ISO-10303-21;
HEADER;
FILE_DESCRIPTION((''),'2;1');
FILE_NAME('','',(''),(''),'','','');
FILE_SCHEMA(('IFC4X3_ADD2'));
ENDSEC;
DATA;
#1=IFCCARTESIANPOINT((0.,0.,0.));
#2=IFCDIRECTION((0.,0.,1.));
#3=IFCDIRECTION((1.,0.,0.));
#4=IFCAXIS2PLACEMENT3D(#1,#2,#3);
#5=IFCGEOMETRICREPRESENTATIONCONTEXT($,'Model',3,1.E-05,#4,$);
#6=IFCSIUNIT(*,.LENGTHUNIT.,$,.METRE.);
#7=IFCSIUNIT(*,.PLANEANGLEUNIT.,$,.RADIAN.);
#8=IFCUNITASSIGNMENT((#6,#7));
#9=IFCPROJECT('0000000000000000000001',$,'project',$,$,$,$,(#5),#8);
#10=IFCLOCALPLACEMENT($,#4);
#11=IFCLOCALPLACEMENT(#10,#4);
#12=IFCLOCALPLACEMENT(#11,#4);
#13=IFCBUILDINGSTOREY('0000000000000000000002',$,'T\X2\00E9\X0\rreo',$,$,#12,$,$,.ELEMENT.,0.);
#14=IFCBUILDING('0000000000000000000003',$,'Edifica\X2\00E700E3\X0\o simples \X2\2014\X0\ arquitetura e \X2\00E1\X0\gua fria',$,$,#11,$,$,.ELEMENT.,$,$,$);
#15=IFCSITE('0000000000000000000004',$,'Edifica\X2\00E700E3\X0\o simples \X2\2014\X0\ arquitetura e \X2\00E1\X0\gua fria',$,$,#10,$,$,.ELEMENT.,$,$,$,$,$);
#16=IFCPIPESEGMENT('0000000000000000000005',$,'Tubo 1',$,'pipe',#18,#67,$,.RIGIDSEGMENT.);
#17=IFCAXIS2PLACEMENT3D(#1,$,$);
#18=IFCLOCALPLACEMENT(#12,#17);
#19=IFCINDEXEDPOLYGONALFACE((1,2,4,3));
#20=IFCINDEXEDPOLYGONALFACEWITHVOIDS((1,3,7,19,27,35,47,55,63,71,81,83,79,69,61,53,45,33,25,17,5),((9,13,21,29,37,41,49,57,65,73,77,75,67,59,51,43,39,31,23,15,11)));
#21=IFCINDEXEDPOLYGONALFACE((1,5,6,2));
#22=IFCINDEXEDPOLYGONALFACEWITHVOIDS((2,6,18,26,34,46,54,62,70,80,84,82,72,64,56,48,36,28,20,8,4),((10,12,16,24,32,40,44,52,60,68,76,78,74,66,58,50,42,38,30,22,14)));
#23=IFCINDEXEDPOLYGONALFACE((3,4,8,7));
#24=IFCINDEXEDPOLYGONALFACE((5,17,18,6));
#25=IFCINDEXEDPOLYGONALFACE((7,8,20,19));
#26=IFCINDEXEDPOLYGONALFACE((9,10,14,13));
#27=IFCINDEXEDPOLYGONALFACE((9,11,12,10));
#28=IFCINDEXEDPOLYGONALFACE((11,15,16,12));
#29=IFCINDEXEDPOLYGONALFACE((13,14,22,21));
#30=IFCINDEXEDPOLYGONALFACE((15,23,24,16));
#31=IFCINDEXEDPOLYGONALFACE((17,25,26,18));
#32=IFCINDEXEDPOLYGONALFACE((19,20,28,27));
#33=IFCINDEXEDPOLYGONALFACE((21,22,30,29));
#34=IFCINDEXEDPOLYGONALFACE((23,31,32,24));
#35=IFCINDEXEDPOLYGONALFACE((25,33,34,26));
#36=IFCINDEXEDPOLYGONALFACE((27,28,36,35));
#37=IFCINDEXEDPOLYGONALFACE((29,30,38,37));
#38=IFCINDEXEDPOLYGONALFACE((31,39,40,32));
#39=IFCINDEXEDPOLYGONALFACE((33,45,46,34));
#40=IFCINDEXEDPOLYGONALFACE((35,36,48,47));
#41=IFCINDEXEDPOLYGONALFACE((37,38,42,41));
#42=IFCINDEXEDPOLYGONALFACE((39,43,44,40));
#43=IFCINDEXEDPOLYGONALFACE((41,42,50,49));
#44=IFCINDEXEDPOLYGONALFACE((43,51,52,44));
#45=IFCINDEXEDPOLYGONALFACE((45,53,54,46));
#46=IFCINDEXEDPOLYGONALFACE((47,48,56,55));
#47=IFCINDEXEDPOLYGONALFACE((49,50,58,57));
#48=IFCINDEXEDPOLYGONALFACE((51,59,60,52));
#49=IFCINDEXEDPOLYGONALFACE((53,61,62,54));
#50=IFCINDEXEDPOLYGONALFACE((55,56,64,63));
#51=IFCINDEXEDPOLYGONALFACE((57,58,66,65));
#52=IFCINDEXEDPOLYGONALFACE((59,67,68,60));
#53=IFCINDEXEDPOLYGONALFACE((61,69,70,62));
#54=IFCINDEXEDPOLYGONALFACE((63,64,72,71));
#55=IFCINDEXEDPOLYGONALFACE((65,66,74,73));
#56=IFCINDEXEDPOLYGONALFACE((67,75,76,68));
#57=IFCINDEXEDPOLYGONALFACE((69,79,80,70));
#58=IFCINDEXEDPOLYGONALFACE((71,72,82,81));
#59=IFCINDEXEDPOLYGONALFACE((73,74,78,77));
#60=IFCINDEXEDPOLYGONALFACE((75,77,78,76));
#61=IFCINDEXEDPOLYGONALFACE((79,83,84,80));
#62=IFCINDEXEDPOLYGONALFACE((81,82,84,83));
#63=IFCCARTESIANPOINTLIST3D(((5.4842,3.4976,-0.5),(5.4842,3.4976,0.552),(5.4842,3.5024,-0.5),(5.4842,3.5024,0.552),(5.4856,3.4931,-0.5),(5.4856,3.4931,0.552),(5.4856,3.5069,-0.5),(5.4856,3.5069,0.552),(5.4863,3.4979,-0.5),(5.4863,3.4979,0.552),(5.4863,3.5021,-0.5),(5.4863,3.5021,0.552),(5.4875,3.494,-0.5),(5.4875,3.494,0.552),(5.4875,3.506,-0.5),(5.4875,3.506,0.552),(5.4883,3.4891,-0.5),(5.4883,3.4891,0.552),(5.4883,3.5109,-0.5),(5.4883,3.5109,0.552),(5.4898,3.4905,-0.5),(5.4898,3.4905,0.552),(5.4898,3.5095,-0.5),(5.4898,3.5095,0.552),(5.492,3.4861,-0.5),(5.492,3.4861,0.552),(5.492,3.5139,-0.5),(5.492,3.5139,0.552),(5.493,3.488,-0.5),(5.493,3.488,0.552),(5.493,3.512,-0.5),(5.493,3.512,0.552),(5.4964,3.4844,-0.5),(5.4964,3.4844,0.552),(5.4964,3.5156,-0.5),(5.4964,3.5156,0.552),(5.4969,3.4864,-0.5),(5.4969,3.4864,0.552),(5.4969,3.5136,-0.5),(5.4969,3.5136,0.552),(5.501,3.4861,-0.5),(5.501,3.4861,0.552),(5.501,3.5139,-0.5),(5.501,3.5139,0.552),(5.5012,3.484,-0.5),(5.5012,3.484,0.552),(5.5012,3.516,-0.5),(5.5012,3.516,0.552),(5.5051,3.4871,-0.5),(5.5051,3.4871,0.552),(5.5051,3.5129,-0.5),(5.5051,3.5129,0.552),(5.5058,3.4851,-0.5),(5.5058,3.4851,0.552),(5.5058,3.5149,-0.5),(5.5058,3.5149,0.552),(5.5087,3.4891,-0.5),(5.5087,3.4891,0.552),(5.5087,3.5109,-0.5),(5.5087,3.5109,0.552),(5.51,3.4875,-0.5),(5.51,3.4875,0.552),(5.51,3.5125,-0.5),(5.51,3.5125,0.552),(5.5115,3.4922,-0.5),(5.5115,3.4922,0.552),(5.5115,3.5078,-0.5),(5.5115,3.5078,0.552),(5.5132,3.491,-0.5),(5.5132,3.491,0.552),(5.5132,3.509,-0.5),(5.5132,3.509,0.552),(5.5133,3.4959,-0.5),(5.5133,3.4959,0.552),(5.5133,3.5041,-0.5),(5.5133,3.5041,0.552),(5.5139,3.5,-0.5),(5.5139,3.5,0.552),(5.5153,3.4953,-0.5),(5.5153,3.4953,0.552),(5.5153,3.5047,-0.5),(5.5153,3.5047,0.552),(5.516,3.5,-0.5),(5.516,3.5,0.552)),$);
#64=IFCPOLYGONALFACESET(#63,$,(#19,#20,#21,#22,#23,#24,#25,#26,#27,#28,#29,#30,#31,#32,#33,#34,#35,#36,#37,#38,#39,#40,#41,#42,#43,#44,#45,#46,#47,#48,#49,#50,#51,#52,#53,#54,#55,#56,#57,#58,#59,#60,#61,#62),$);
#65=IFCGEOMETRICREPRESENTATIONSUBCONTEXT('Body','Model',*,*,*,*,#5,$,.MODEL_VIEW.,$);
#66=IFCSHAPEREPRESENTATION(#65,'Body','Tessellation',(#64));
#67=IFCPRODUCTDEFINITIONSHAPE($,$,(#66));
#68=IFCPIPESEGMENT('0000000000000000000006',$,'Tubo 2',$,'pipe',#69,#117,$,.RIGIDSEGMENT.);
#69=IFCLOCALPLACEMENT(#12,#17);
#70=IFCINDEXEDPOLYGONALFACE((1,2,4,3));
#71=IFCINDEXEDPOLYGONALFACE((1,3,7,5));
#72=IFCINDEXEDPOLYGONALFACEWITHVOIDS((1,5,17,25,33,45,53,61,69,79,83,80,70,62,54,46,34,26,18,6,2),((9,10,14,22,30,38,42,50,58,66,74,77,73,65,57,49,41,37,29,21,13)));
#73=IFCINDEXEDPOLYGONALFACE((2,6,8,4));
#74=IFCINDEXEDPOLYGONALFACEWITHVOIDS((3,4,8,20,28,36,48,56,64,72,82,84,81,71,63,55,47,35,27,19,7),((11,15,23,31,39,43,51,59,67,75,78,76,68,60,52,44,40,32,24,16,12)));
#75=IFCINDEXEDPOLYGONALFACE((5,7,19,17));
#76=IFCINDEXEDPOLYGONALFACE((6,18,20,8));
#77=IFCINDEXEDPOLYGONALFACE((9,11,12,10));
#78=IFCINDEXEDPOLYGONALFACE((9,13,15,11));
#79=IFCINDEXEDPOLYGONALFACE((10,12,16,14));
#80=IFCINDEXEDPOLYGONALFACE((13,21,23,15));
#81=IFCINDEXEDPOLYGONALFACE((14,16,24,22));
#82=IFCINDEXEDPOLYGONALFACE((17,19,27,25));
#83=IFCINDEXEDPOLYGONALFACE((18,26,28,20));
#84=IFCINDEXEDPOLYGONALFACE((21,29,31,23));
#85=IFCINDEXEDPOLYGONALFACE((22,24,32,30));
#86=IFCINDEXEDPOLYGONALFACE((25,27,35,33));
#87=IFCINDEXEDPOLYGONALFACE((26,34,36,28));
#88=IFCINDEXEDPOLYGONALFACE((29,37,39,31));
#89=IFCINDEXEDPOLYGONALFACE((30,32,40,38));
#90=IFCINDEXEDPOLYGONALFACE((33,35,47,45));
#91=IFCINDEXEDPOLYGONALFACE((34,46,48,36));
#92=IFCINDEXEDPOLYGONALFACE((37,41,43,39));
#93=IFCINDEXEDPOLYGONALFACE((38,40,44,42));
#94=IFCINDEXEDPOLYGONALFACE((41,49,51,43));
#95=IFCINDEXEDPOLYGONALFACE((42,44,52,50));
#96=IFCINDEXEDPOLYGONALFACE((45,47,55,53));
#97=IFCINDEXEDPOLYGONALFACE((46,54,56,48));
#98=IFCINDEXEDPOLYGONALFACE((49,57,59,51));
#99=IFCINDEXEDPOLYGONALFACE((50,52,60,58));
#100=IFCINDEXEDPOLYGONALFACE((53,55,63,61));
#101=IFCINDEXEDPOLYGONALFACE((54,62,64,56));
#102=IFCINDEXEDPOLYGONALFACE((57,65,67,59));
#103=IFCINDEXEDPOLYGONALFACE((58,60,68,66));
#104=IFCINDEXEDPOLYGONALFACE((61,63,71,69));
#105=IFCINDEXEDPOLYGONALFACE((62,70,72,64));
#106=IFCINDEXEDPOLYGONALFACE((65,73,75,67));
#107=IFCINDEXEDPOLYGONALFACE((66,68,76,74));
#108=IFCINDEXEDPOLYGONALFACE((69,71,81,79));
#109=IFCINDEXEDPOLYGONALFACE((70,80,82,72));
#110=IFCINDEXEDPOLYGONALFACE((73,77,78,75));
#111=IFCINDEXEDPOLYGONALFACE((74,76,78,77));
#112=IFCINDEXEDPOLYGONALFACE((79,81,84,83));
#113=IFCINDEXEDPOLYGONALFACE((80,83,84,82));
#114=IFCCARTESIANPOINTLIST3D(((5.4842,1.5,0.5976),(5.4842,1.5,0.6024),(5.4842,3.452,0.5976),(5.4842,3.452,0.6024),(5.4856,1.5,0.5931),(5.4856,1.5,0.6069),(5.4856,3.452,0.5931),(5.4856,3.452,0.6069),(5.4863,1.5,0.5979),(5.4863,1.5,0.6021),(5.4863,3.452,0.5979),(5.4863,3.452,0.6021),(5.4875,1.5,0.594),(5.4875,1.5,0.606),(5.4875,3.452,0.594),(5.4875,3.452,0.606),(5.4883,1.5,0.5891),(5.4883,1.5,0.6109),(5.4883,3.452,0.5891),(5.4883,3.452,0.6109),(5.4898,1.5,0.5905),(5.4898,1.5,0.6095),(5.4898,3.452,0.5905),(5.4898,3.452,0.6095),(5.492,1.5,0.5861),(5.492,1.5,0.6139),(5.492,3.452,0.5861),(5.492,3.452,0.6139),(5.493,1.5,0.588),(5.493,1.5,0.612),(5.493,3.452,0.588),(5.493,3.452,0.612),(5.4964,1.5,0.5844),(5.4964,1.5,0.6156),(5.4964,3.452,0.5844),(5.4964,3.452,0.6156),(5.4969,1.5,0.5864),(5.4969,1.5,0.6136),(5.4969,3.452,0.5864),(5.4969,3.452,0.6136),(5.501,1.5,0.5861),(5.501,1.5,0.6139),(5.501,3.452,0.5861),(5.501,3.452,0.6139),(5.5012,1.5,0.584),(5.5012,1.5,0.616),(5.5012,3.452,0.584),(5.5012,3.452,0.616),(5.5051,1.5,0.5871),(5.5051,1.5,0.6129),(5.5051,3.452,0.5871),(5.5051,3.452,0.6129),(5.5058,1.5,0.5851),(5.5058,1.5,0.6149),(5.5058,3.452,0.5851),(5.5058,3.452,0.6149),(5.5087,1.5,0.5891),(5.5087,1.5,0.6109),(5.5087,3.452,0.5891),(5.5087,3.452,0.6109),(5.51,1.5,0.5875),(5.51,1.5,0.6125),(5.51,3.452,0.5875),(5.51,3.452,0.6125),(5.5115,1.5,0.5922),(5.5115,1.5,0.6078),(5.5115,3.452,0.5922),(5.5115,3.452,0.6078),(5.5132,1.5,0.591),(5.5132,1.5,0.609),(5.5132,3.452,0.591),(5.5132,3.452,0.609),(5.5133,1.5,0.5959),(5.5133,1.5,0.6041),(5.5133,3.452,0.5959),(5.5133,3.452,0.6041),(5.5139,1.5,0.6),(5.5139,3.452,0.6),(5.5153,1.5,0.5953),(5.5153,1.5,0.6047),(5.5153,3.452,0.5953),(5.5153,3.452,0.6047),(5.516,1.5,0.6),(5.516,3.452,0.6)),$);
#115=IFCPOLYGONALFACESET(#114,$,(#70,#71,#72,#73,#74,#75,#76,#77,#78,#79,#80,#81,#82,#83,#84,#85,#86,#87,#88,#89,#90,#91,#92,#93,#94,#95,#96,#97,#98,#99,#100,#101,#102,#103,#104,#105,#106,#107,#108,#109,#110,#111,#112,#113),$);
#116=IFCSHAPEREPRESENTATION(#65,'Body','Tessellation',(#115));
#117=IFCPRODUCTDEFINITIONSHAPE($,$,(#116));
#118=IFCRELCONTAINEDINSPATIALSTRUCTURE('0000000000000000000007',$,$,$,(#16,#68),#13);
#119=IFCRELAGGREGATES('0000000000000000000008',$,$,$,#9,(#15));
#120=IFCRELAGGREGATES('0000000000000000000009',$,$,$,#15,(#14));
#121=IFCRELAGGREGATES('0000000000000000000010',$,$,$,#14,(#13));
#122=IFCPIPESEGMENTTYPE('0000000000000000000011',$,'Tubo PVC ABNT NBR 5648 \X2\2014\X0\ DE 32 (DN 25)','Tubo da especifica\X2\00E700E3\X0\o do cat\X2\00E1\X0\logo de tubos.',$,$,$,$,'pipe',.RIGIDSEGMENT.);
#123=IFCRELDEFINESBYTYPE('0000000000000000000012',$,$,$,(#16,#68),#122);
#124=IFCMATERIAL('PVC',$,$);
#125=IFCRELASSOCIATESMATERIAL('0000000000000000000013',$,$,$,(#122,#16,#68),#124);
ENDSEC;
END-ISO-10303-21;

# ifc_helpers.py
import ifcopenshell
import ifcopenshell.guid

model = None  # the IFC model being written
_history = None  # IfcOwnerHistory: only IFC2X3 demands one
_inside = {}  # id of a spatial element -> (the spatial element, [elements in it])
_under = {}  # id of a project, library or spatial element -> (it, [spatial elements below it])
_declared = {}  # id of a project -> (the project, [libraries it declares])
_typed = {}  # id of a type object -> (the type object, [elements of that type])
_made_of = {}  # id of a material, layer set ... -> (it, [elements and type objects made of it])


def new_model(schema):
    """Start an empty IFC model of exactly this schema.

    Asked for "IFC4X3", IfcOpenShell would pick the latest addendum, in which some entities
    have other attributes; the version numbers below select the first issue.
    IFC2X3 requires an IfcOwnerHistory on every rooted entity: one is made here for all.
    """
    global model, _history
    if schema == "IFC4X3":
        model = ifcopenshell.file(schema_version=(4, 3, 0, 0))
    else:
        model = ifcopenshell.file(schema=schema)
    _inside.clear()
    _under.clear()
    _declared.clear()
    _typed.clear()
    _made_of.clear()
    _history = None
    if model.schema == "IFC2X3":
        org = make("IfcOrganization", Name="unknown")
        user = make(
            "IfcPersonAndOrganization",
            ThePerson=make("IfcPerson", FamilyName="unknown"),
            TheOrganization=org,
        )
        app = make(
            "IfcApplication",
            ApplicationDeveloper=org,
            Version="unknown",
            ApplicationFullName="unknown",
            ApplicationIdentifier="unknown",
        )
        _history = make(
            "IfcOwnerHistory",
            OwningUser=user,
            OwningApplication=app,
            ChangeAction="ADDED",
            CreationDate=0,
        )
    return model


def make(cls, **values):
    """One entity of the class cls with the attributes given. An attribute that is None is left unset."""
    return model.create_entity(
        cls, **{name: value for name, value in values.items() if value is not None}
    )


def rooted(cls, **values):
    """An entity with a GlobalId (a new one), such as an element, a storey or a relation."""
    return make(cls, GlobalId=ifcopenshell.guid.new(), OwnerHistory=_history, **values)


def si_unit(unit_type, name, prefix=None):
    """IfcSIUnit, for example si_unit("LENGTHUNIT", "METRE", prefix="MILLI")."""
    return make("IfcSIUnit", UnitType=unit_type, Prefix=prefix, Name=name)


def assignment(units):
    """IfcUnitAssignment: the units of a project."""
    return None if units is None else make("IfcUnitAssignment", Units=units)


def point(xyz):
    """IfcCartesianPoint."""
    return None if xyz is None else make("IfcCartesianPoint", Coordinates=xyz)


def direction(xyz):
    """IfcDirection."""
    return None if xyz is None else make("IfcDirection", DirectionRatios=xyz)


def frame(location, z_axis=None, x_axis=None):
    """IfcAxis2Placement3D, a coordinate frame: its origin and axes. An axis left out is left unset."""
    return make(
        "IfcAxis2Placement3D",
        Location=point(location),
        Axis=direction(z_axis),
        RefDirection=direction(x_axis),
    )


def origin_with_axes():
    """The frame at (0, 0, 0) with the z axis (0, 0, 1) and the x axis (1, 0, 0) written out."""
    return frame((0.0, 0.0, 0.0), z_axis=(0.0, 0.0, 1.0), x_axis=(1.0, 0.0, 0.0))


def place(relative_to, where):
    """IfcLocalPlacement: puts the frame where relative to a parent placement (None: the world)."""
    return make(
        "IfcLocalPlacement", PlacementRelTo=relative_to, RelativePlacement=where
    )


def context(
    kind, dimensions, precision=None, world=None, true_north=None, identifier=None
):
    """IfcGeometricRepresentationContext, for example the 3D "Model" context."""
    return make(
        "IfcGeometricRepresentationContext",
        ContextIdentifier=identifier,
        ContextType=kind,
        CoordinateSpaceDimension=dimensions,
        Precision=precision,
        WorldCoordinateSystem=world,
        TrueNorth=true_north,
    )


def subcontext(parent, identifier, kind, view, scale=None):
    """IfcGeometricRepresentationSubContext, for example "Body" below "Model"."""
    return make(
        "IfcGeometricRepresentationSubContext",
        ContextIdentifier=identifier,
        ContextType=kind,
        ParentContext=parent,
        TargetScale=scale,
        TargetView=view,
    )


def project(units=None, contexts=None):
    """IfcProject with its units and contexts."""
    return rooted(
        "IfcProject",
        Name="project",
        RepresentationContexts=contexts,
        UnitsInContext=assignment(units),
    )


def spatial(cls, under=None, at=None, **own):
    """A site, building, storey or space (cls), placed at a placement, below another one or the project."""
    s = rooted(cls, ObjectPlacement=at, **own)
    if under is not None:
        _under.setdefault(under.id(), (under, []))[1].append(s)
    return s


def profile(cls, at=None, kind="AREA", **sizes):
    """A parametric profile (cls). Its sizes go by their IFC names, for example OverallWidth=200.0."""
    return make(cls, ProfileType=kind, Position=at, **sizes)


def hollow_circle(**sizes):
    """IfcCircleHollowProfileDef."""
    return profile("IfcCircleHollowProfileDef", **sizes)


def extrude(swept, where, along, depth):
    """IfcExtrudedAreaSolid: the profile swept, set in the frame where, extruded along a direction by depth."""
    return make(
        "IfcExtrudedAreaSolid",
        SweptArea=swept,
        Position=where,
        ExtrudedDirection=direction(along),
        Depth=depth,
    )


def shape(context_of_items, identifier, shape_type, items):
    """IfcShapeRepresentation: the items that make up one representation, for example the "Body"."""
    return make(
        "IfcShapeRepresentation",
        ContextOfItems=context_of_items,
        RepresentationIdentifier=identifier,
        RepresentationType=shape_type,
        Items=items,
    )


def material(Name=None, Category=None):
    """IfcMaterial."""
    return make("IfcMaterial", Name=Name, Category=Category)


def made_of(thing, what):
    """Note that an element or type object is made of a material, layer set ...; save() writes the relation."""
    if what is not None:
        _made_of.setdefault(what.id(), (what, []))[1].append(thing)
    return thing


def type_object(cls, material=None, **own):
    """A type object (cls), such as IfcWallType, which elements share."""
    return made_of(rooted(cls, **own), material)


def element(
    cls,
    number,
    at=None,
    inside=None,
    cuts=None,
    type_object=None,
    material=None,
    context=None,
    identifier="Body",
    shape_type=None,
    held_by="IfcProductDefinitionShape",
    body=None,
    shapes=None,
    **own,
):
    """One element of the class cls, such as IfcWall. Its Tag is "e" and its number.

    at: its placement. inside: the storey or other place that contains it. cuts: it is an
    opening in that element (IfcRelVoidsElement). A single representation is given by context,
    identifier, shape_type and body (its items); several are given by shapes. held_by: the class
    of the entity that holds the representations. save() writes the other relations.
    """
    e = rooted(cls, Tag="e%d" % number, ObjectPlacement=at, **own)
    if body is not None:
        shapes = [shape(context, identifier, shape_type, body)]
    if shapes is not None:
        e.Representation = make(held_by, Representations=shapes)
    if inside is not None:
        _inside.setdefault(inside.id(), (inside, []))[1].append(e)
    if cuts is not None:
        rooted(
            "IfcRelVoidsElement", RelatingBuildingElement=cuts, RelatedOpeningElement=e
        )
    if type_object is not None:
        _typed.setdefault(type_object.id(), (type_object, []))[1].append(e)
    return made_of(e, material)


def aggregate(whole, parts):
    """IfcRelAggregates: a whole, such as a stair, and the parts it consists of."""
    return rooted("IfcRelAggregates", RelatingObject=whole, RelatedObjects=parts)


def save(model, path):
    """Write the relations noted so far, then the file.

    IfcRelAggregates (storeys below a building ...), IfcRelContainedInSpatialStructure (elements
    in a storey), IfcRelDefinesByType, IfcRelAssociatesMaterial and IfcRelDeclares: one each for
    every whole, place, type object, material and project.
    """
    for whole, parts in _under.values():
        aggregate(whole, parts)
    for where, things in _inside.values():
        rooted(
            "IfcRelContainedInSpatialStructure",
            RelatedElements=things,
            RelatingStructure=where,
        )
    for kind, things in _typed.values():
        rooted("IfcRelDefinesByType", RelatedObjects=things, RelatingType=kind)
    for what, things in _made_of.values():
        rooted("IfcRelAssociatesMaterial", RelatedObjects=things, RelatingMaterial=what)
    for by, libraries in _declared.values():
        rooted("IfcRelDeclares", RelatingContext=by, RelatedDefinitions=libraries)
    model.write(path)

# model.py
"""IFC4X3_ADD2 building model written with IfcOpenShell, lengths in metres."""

from ifc_helpers import new_model, si_unit, frame, origin_with_axes, place, context, subcontext, project, spatial, hollow_circle, extrude, material, type_object, element, save


model = new_model("IFC4X3_ADD2")

# Units and contexts
model_context = context("Model", 3, precision=1e-05, world=origin_with_axes())
body_context = subcontext(model_context, "Body", "Model", "MODEL_VIEW")
ifc_project = project(units=[si_unit("LENGTHUNIT", "METRE"), si_unit("PLANEANGLEUNIT", "RADIAN")], contexts=[model_context])

# Site, building, storey
site_placement = place(None, origin_with_axes())
site = spatial("IfcSite", under=ifc_project, at=site_placement, Name="Edificação simples — arquitetura e água fria", CompositionType="ELEMENT")
building_placement = place(site_placement, origin_with_axes())
building = spatial("IfcBuilding", under=site, at=building_placement, Name="Edificação simples — arquitetura e água fria", CompositionType="ELEMENT")
storey_placement = place(building_placement, origin_with_axes())
storey = spatial("IfcBuildingStorey", under=building, at=storey_placement, Name="Térreo", CompositionType="ELEMENT", Elevation=0.0)

# Pipe segments
ifc_material_1 = material(Name="PVC")
pipe_segment_type = type_object("IfcPipeSegmentType", Name="Tubo PVC ABNT NBR 5648 — DE 32 (DN 25)", Description="Tubo da especificação do catálogo de tubos.", ElementType="pipe", PredefinedType="RIGIDSEGMENT", material=ifc_material_1)
pipe_segment_1_placement = place(storey_placement, frame((5.5, 3.5, -0.5), z_axis=(0.0, 1.0, 0.0), x_axis=(0.0, 0.0, 1.0)))
element("IfcPipeSegment", 1, at=pipe_segment_1_placement, inside=storey, type_object=pipe_segment_type, material=ifc_material_1, Name="Tubo 1", ObjectType="pipe", PredefinedType="RIGIDSEGMENT", context=body_context, shape_type="SweptSolid", body=[
    extrude(hollow_circle(Radius=0.016, WallThickness=0.0021), frame((0.0, 0.0, 0.0), z_axis=(1.0, 0.0, 0.0), x_axis=(0.0, 1.0, 0.0)), (0.0, 0.0, 1.0), 1.052),
])
pipe_segment_2_placement = place(storey_placement, frame((5.5, 3.452, 0.6), z_axis=(0.0, 0.0, 1.0), x_axis=(0.0, -1.0, 0.0)))
element("IfcPipeSegment", 2, at=pipe_segment_2_placement, inside=storey, type_object=pipe_segment_type, material=ifc_material_1, Name="Tubo 2", ObjectType="pipe", PredefinedType="RIGIDSEGMENT", context=body_context, shape_type="SweptSolid", body=[
    extrude(hollow_circle(Radius=0.016, WallThickness=0.0021), frame((0.0, 0.0, 0.0), z_axis=(1.0, 0.0, 0.0), x_axis=(0.0, 1.0, 0.0)), (0.0, 0.0, 1.0), 1.952),
])

save(model, "model.ifc")
